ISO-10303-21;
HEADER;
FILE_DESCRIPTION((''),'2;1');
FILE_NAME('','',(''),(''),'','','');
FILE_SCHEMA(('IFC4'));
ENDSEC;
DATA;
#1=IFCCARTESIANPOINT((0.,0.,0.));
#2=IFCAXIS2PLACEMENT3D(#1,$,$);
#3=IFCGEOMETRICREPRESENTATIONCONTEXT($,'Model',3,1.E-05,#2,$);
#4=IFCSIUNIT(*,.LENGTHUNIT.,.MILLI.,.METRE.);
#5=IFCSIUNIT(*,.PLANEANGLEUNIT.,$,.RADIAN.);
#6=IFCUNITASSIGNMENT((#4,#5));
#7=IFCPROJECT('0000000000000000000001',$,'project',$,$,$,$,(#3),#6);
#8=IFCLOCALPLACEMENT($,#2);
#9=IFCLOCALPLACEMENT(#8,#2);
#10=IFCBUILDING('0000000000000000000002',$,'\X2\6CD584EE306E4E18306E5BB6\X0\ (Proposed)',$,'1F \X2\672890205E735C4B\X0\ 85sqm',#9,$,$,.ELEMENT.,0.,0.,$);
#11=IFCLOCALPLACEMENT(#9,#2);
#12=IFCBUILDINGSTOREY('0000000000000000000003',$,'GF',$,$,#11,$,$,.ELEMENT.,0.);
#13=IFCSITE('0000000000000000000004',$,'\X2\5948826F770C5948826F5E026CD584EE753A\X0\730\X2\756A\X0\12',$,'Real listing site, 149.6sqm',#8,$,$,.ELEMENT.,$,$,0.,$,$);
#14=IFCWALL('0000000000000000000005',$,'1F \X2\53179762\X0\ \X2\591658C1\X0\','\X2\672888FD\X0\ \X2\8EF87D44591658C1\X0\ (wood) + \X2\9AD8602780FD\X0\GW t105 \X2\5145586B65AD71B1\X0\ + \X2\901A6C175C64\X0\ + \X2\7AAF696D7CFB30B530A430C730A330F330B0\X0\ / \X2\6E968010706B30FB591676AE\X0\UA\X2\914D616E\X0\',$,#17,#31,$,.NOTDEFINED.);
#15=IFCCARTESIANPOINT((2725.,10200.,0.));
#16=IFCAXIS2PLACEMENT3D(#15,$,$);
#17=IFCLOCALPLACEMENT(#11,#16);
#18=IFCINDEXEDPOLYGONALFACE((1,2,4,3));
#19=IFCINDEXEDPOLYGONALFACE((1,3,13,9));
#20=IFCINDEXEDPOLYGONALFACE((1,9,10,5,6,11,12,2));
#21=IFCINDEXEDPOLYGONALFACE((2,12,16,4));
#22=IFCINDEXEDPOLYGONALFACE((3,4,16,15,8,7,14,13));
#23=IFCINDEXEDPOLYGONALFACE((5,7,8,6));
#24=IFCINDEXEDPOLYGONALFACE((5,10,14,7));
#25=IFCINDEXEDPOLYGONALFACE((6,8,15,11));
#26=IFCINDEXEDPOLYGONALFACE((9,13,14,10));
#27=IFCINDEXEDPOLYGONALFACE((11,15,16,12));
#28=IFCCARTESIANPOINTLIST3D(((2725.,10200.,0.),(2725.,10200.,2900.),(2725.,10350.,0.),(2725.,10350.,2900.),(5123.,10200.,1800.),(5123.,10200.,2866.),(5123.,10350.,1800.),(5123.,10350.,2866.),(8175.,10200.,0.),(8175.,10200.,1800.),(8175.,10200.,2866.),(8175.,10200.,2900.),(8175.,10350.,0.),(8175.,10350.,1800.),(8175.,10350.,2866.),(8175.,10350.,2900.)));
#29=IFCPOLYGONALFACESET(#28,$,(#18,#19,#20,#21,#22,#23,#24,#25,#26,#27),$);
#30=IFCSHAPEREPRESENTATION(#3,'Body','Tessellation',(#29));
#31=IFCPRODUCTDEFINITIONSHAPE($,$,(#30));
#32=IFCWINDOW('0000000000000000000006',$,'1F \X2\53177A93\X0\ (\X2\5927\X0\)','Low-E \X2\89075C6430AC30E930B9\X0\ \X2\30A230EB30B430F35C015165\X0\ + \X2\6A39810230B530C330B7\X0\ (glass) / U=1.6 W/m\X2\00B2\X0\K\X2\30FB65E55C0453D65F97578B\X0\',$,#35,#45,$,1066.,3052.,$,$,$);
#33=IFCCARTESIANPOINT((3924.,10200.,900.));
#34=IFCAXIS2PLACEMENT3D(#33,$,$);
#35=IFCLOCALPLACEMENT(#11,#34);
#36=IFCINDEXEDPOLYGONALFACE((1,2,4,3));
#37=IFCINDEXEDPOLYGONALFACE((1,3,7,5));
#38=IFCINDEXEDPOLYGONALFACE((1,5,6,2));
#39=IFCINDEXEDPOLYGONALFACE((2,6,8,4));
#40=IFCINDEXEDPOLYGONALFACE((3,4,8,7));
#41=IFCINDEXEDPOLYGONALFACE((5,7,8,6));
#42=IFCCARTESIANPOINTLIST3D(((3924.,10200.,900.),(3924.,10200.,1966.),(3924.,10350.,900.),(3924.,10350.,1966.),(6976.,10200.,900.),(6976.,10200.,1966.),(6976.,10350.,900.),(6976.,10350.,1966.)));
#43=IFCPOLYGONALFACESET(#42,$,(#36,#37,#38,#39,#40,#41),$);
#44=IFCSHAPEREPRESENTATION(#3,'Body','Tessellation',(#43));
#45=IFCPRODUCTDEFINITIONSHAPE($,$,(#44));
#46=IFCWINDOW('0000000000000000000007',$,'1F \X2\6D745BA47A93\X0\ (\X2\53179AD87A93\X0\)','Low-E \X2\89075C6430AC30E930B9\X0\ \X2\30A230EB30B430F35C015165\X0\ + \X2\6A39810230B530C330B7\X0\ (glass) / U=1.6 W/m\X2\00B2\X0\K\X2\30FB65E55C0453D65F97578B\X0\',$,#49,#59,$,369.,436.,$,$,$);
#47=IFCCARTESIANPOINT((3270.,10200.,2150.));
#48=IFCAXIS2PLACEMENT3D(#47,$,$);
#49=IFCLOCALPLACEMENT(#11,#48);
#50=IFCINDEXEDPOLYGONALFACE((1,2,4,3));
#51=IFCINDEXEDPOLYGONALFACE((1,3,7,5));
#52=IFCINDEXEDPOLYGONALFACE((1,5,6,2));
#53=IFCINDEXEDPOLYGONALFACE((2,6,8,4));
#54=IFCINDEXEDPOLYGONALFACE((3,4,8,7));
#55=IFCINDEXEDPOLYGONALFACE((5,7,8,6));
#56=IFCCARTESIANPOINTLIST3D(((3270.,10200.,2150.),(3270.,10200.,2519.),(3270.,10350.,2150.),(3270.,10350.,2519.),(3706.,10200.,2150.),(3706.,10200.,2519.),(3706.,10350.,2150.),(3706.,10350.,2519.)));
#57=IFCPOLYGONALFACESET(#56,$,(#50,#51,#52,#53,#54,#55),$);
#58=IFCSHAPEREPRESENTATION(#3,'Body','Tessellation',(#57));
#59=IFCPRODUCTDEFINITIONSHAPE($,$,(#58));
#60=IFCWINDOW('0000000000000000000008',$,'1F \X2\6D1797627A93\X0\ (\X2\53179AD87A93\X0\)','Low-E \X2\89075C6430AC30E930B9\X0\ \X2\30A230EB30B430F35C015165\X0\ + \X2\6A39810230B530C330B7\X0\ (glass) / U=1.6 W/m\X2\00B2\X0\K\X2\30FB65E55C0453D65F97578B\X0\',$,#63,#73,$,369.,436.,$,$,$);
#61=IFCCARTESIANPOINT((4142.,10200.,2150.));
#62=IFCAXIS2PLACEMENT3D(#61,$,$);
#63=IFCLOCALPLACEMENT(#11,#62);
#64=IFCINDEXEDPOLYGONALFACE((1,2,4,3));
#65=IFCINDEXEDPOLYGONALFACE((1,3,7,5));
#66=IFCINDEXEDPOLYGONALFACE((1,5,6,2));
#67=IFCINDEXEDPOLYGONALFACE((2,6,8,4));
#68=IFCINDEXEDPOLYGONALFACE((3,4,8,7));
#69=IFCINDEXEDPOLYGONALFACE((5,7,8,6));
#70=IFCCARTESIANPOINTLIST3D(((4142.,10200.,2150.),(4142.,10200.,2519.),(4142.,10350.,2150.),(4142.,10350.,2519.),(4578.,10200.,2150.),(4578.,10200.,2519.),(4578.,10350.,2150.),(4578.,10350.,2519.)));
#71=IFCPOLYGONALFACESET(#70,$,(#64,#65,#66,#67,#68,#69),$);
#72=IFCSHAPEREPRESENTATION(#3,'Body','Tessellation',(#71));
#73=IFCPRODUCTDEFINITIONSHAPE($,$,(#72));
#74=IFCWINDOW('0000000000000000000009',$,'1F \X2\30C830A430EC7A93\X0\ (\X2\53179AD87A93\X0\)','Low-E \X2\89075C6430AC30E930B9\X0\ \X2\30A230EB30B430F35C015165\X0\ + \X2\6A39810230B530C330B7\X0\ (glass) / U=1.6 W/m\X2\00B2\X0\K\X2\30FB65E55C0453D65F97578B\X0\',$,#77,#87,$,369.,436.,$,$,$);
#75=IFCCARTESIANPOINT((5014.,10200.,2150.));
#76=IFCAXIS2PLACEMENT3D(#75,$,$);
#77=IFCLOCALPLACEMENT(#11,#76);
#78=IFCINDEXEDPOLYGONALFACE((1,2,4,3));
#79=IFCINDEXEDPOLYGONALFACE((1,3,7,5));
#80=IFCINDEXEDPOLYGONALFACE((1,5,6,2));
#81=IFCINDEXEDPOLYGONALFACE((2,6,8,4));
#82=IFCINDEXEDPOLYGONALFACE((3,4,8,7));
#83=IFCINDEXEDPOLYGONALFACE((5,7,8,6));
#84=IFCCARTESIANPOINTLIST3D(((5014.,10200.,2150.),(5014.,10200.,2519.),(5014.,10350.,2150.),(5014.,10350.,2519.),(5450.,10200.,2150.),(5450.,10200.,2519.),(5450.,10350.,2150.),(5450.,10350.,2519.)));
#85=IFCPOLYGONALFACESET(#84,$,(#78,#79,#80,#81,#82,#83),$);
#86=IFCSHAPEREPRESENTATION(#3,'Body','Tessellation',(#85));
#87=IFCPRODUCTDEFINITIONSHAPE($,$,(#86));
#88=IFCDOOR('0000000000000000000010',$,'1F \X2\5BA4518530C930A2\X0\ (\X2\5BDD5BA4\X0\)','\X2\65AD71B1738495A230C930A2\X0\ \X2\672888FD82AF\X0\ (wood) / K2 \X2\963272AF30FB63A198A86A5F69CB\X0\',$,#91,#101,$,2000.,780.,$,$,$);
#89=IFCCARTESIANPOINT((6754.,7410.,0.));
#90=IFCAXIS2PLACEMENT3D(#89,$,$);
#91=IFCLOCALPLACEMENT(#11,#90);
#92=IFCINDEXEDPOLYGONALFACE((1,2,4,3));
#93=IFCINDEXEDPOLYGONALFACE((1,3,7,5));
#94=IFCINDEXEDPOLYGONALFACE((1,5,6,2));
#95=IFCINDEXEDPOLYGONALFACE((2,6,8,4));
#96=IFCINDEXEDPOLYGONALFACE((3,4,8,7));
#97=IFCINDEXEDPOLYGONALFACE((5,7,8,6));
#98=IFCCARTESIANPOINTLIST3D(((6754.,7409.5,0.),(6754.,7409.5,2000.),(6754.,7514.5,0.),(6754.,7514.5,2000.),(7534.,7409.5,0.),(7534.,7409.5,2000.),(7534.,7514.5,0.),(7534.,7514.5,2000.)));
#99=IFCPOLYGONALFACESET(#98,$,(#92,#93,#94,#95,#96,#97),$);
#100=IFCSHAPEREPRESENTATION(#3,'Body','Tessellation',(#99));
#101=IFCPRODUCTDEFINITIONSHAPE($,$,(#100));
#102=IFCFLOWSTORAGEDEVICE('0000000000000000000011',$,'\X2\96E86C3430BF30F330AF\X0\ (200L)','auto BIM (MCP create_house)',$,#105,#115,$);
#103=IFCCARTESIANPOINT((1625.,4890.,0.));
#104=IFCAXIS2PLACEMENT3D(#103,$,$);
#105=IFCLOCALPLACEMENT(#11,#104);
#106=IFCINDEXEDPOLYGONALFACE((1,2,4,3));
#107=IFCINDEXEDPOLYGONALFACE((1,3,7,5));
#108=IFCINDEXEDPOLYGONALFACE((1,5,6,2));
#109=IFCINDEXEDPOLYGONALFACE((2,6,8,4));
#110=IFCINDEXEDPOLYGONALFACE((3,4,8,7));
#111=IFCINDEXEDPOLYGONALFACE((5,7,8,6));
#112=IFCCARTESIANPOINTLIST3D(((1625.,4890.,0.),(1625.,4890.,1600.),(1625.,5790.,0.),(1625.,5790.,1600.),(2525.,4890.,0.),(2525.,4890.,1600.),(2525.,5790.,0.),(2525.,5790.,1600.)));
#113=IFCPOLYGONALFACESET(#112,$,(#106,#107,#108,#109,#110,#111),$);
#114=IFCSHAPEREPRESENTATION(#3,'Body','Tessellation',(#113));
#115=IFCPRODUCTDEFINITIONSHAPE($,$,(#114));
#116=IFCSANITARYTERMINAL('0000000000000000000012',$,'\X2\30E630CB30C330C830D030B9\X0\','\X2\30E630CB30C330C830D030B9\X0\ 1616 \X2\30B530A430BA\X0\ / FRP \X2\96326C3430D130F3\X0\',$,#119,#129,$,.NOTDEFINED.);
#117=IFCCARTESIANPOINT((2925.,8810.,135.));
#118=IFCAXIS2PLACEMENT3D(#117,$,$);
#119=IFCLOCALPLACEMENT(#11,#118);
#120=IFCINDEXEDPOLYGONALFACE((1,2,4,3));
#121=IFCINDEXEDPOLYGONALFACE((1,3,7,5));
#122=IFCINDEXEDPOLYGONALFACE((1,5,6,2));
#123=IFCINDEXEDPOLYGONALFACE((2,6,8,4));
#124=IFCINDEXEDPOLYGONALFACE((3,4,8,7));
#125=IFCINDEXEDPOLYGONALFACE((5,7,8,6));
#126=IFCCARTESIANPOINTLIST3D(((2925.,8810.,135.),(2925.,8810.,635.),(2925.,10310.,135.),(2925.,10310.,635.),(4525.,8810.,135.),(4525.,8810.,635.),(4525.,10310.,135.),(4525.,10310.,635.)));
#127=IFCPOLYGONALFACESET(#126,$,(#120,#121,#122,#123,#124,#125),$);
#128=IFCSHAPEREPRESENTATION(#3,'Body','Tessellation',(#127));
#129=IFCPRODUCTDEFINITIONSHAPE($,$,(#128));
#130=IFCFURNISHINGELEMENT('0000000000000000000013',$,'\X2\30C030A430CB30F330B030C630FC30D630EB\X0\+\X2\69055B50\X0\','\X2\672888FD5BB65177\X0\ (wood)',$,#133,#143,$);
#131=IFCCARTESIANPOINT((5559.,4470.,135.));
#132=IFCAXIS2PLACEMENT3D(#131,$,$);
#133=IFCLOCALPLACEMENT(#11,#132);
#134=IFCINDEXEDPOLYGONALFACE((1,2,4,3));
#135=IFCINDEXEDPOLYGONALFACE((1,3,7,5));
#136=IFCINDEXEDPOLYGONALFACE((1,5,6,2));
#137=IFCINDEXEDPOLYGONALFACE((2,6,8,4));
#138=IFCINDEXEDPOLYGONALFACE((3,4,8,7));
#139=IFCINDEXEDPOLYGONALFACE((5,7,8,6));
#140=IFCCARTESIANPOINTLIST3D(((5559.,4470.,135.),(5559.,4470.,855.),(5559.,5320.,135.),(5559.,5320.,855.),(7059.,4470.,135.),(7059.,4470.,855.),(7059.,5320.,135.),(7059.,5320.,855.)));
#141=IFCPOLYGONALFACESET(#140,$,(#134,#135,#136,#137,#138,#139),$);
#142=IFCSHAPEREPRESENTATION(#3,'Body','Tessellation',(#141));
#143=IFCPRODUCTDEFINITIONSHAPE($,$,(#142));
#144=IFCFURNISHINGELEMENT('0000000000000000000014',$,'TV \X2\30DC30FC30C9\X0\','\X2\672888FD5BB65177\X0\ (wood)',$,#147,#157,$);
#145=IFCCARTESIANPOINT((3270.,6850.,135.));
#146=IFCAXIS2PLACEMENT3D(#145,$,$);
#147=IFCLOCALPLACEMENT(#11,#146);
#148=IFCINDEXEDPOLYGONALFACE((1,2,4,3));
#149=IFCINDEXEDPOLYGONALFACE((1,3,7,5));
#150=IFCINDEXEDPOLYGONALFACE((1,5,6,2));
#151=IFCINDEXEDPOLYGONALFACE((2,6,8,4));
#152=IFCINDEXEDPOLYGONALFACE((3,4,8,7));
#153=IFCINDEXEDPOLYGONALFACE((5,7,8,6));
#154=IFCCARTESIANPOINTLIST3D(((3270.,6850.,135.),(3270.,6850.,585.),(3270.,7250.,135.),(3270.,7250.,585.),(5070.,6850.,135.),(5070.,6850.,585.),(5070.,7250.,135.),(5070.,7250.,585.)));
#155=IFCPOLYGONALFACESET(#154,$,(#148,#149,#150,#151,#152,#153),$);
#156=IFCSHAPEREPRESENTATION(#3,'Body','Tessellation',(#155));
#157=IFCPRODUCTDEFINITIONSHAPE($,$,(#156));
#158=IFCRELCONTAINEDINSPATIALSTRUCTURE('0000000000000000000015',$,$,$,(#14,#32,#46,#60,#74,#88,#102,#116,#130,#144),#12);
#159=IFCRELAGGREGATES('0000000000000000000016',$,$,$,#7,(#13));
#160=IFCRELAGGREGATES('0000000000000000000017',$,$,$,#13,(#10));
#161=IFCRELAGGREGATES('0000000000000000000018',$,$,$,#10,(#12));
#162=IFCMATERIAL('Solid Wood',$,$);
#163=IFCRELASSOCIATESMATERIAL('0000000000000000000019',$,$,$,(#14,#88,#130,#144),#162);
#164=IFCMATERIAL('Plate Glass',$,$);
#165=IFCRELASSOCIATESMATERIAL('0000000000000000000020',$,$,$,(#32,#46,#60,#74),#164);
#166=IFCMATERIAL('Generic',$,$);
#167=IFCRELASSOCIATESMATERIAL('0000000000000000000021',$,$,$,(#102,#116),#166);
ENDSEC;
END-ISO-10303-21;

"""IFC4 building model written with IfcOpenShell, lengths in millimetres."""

from ifc_helpers import new_model, si_unit, frame, frame_2d, origin, place, context, project, spatial, rectangle, extrude, material, element, fill, save


model = new_model("IFC4")

# Units and contexts
model_context = context("Model", 3, precision=1e-05, world=origin())
ifc_project = project(units=[si_unit("LENGTHUNIT", "METRE", prefix="MILLI"), si_unit("PLANEANGLEUNIT", "RADIAN")], contexts=[model_context])

# Site, building, storey
site_placement = place(None, origin())
site = spatial("IfcSite", under=ifc_project, at=site_placement, Name="奈良県奈良市法蓮町730番12", ObjectType="Real listing site, 149.6sqm", CompositionType="ELEMENT", RefElevation=0.0)
building_placement = place(site_placement, origin())
building = spatial("IfcBuilding", under=site, at=building_placement, Name="法蓮の丘の家 (Proposed)", ObjectType="1F 木造平屋 85sqm", CompositionType="ELEMENT", ElevationOfRefHeight=0.0, ElevationOfTerrain=0.0)
storey_placement = place(building_placement, origin())
storey = spatial("IfcBuildingStorey", under=building, at=storey_placement, Name="GF", CompositionType="ELEMENT", Elevation=0.0)

# Wall, openings, windows
ifc_material_1 = material(Name="Solid Wood")
wall_1_placement = place(storey_placement, frame((2725.0, 10200.0, 0.0)))
wall_1 = element("IfcWall", 1, at=wall_1_placement, inside=storey, material=ifc_material_1, Name="1F 北面 外壁", Description="木製 軸組外壁 (wood) + 高性能GW t105 充填断熱 + 通気層 + 窯業系サイディング / 準耐火・外皮UA配慮", PredefinedType="NOTDEFINED", context=model_context, shape_type="SweptSolid", body=[
    extrude(rectangle(XDim=5450.0, YDim=150.0, at=frame_2d((2725.0, 75.0))), frame((2725.0, 10200.0, 0.0)), (0.0, 0.0, 1.0), 2900.0),
])
opening_1_placement = place(storey_placement, frame((3924.0, 10200.0, 900.0)))
opening_1 = element("IfcOpeningElement", 2, at=opening_1_placement, cuts=wall_1, PredefinedType="NOTDEFINED", context=model_context, shape_type="SweptSolid", body=[
    extrude(rectangle(XDim=3052.0, YDim=150.0, at=frame_2d((1526.0, 75.0))), frame((3924.0, 10200.0, 900.0)), (0.0, 0.0, 1.0), 1066.0),
])
opening_2_placement = place(storey_placement, frame((3270.0, 10200.0, 2150.0)))
opening_2 = element("IfcOpeningElement", 3, at=opening_2_placement, cuts=wall_1, PredefinedType="NOTDEFINED", context=model_context, shape_type="SweptSolid", body=[
    extrude(rectangle(XDim=436.0, YDim=150.0, at=frame_2d((218.0, 75.0))), frame((3270.0, 10200.0, 2150.0)), (0.0, 0.0, 1.0), 369.0),
])
opening_3_placement = place(storey_placement, frame((4142.0, 10200.0, 2150.0)))
opening_3 = element("IfcOpeningElement", 4, at=opening_3_placement, cuts=wall_1, PredefinedType="NOTDEFINED", context=model_context, shape_type="SweptSolid", body=[
    extrude(rectangle(XDim=436.0, YDim=150.0, at=frame_2d((218.0, 75.0))), frame((4142.0, 10200.0, 2150.0)), (0.0, 0.0, 1.0), 369.0),
])
opening_4_placement = place(storey_placement, frame((5014.0, 10200.0, 2150.0)))
opening_4 = element("IfcOpeningElement", 5, at=opening_4_placement, cuts=wall_1, PredefinedType="NOTDEFINED", context=model_context, shape_type="SweptSolid", body=[
    extrude(rectangle(XDim=436.0, YDim=150.0, at=frame_2d((218.0, 75.0))), frame((5014.0, 10200.0, 2150.0)), (0.0, 0.0, 1.0), 369.0),
])
ifc_material_2 = material(Name="Plate Glass")
window_1_placement = place(storey_placement, frame((3924.0, 10200.0, 900.0)))
window_1 = element("IfcWindow", 6, at=window_1_placement, inside=storey, material=ifc_material_2, Name="1F 北窓 (大)", Description="Low-E 複層ガラス アルゴン封入 + 樹脂サッシ (glass) / U=1.6 W/m²K・日射取得型", OverallHeight=1066.0, OverallWidth=3052.0, context=model_context, shape_type="SweptSolid", body=[
    extrude(rectangle(XDim=3052.0, YDim=150.0, at=frame_2d((1526.0, 75.0))), frame((3924.0, 10200.0, 900.0)), (0.0, 0.0, 1.0), 1066.0),
])
fill(opening_1, window_1)
window_2_placement = place(storey_placement, frame((3270.0, 10200.0, 2150.0)))
window_2 = element("IfcWindow", 7, at=window_2_placement, inside=storey, material=ifc_material_2, Name="1F 浴室窓 (北高窓)", Description="Low-E 複層ガラス アルゴン封入 + 樹脂サッシ (glass) / U=1.6 W/m²K・日射取得型", OverallHeight=369.0, OverallWidth=436.0, context=model_context, shape_type="SweptSolid", body=[
    extrude(rectangle(XDim=436.0, YDim=150.0, at=frame_2d((218.0, 75.0))), frame((3270.0, 10200.0, 2150.0)), (0.0, 0.0, 1.0), 369.0),
])
fill(opening_2, window_2)
window_3_placement = place(storey_placement, frame((4142.0, 10200.0, 2150.0)))
window_3 = element("IfcWindow", 8, at=window_3_placement, inside=storey, material=ifc_material_2, Name="1F 洗面窓 (北高窓)", Description="Low-E 複層ガラス アルゴン封入 + 樹脂サッシ (glass) / U=1.6 W/m²K・日射取得型", OverallHeight=369.0, OverallWidth=436.0, context=model_context, shape_type="SweptSolid", body=[
    extrude(rectangle(XDim=436.0, YDim=150.0, at=frame_2d((218.0, 75.0))), frame((4142.0, 10200.0, 2150.0)), (0.0, 0.0, 1.0), 369.0),
])
fill(opening_3, window_3)
window_4_placement = place(storey_placement, frame((5014.0, 10200.0, 2150.0)))
window_4 = element("IfcWindow", 9, at=window_4_placement, inside=storey, material=ifc_material_2, Name="1F トイレ窓 (北高窓)", Description="Low-E 複層ガラス アルゴン封入 + 樹脂サッシ (glass) / U=1.6 W/m²K・日射取得型", OverallHeight=369.0, OverallWidth=436.0, context=model_context, shape_type="SweptSolid", body=[
    extrude(rectangle(XDim=436.0, YDim=150.0, at=frame_2d((218.0, 75.0))), frame((5014.0, 10200.0, 2150.0)), (0.0, 0.0, 1.0), 369.0),
])
fill(opening_4, window_4)

# Door
door_1_placement = place(storey_placement, frame((6754.0, 7410.0, 0.0)))
element("IfcDoor", 10, at=door_1_placement, inside=storey, material=ifc_material_1, Name="1F 室内ドア (寝室)", Description="断熱玄関ドア 木製芯 (wood) / K2 防犯・採風機構", OverallHeight=2000.0, OverallWidth=780.0, context=model_context, shape_type="SweptSolid", body=[
    extrude(rectangle(XDim=780.0, YDim=105.0, at=frame_2d((390.0, 52.0))), frame((6754.0, 7410.0, 0.0)), (0.0, 0.0, 1.0), 2000.0),
])

# Flow storage device
ifc_material_3 = material(Name="Generic")
flow_storage_device_placement = place(storey_placement, frame((1625.0, 4890.0, 0.0)))
element("IfcFlowStorageDevice", 11, at=flow_storage_device_placement, inside=storey, material=ifc_material_3, Name="雨水タンク (200L)", Description="auto BIM (MCP create_house)", context=model_context, shape_type="SweptSolid", body=[
    extrude(rectangle(XDim=900.0, YDim=900.0, at=frame_2d((450.0, 450.0))), frame((1625.0, 4890.0, 0.0)), (0.0, 0.0, 1.0), 1600.0),
])

# Sanitary terminal
sanitary_terminal_placement = place(storey_placement, frame((2925.0, 8810.0, 135.0)))
element("IfcSanitaryTerminal", 12, at=sanitary_terminal_placement, inside=storey, material=ifc_material_3, Name="ユニットバス", Description="ユニットバス 1616 サイズ / FRP 防水パン", PredefinedType="NOTDEFINED", context=model_context, shape_type="SweptSolid", body=[
    extrude(rectangle(XDim=1600.0, YDim=1500.0, at=frame_2d((800.0, 750.0))), frame((2925.0, 8810.0, 135.0)), (0.0, 0.0, 1.0), 500.0),
])

# Furnishing elements
furnishing_1_placement = place(storey_placement, frame((5559.0, 4470.0, 135.0)))
element("IfcFurnishingElement", 13, at=furnishing_1_placement, inside=storey, material=ifc_material_1, Name="ダイニングテーブル+椅子", Description="木製家具 (wood)", context=model_context, shape_type="SweptSolid", body=[
    extrude(rectangle(XDim=1500.0, YDim=850.0, at=frame_2d((750.0, 425.0))), frame((5559.0, 4470.0, 135.0)), (0.0, 0.0, 1.0), 720.0),
])
furnishing_2_placement = place(storey_placement, frame((3270.0, 6850.0, 135.0)))
element("IfcFurnishingElement", 14, at=furnishing_2_placement, inside=storey, material=ifc_material_1, Name="TV ボード", Description="木製家具 (wood)", context=model_context, shape_type="SweptSolid", body=[
    extrude(rectangle(XDim=1800.0, YDim=400.0, at=frame_2d((900.0, 200.0))), frame((3270.0, 6850.0, 135.0)), (0.0, 0.0, 1.0), 450.0),
])

save(model, "model.ifc")
